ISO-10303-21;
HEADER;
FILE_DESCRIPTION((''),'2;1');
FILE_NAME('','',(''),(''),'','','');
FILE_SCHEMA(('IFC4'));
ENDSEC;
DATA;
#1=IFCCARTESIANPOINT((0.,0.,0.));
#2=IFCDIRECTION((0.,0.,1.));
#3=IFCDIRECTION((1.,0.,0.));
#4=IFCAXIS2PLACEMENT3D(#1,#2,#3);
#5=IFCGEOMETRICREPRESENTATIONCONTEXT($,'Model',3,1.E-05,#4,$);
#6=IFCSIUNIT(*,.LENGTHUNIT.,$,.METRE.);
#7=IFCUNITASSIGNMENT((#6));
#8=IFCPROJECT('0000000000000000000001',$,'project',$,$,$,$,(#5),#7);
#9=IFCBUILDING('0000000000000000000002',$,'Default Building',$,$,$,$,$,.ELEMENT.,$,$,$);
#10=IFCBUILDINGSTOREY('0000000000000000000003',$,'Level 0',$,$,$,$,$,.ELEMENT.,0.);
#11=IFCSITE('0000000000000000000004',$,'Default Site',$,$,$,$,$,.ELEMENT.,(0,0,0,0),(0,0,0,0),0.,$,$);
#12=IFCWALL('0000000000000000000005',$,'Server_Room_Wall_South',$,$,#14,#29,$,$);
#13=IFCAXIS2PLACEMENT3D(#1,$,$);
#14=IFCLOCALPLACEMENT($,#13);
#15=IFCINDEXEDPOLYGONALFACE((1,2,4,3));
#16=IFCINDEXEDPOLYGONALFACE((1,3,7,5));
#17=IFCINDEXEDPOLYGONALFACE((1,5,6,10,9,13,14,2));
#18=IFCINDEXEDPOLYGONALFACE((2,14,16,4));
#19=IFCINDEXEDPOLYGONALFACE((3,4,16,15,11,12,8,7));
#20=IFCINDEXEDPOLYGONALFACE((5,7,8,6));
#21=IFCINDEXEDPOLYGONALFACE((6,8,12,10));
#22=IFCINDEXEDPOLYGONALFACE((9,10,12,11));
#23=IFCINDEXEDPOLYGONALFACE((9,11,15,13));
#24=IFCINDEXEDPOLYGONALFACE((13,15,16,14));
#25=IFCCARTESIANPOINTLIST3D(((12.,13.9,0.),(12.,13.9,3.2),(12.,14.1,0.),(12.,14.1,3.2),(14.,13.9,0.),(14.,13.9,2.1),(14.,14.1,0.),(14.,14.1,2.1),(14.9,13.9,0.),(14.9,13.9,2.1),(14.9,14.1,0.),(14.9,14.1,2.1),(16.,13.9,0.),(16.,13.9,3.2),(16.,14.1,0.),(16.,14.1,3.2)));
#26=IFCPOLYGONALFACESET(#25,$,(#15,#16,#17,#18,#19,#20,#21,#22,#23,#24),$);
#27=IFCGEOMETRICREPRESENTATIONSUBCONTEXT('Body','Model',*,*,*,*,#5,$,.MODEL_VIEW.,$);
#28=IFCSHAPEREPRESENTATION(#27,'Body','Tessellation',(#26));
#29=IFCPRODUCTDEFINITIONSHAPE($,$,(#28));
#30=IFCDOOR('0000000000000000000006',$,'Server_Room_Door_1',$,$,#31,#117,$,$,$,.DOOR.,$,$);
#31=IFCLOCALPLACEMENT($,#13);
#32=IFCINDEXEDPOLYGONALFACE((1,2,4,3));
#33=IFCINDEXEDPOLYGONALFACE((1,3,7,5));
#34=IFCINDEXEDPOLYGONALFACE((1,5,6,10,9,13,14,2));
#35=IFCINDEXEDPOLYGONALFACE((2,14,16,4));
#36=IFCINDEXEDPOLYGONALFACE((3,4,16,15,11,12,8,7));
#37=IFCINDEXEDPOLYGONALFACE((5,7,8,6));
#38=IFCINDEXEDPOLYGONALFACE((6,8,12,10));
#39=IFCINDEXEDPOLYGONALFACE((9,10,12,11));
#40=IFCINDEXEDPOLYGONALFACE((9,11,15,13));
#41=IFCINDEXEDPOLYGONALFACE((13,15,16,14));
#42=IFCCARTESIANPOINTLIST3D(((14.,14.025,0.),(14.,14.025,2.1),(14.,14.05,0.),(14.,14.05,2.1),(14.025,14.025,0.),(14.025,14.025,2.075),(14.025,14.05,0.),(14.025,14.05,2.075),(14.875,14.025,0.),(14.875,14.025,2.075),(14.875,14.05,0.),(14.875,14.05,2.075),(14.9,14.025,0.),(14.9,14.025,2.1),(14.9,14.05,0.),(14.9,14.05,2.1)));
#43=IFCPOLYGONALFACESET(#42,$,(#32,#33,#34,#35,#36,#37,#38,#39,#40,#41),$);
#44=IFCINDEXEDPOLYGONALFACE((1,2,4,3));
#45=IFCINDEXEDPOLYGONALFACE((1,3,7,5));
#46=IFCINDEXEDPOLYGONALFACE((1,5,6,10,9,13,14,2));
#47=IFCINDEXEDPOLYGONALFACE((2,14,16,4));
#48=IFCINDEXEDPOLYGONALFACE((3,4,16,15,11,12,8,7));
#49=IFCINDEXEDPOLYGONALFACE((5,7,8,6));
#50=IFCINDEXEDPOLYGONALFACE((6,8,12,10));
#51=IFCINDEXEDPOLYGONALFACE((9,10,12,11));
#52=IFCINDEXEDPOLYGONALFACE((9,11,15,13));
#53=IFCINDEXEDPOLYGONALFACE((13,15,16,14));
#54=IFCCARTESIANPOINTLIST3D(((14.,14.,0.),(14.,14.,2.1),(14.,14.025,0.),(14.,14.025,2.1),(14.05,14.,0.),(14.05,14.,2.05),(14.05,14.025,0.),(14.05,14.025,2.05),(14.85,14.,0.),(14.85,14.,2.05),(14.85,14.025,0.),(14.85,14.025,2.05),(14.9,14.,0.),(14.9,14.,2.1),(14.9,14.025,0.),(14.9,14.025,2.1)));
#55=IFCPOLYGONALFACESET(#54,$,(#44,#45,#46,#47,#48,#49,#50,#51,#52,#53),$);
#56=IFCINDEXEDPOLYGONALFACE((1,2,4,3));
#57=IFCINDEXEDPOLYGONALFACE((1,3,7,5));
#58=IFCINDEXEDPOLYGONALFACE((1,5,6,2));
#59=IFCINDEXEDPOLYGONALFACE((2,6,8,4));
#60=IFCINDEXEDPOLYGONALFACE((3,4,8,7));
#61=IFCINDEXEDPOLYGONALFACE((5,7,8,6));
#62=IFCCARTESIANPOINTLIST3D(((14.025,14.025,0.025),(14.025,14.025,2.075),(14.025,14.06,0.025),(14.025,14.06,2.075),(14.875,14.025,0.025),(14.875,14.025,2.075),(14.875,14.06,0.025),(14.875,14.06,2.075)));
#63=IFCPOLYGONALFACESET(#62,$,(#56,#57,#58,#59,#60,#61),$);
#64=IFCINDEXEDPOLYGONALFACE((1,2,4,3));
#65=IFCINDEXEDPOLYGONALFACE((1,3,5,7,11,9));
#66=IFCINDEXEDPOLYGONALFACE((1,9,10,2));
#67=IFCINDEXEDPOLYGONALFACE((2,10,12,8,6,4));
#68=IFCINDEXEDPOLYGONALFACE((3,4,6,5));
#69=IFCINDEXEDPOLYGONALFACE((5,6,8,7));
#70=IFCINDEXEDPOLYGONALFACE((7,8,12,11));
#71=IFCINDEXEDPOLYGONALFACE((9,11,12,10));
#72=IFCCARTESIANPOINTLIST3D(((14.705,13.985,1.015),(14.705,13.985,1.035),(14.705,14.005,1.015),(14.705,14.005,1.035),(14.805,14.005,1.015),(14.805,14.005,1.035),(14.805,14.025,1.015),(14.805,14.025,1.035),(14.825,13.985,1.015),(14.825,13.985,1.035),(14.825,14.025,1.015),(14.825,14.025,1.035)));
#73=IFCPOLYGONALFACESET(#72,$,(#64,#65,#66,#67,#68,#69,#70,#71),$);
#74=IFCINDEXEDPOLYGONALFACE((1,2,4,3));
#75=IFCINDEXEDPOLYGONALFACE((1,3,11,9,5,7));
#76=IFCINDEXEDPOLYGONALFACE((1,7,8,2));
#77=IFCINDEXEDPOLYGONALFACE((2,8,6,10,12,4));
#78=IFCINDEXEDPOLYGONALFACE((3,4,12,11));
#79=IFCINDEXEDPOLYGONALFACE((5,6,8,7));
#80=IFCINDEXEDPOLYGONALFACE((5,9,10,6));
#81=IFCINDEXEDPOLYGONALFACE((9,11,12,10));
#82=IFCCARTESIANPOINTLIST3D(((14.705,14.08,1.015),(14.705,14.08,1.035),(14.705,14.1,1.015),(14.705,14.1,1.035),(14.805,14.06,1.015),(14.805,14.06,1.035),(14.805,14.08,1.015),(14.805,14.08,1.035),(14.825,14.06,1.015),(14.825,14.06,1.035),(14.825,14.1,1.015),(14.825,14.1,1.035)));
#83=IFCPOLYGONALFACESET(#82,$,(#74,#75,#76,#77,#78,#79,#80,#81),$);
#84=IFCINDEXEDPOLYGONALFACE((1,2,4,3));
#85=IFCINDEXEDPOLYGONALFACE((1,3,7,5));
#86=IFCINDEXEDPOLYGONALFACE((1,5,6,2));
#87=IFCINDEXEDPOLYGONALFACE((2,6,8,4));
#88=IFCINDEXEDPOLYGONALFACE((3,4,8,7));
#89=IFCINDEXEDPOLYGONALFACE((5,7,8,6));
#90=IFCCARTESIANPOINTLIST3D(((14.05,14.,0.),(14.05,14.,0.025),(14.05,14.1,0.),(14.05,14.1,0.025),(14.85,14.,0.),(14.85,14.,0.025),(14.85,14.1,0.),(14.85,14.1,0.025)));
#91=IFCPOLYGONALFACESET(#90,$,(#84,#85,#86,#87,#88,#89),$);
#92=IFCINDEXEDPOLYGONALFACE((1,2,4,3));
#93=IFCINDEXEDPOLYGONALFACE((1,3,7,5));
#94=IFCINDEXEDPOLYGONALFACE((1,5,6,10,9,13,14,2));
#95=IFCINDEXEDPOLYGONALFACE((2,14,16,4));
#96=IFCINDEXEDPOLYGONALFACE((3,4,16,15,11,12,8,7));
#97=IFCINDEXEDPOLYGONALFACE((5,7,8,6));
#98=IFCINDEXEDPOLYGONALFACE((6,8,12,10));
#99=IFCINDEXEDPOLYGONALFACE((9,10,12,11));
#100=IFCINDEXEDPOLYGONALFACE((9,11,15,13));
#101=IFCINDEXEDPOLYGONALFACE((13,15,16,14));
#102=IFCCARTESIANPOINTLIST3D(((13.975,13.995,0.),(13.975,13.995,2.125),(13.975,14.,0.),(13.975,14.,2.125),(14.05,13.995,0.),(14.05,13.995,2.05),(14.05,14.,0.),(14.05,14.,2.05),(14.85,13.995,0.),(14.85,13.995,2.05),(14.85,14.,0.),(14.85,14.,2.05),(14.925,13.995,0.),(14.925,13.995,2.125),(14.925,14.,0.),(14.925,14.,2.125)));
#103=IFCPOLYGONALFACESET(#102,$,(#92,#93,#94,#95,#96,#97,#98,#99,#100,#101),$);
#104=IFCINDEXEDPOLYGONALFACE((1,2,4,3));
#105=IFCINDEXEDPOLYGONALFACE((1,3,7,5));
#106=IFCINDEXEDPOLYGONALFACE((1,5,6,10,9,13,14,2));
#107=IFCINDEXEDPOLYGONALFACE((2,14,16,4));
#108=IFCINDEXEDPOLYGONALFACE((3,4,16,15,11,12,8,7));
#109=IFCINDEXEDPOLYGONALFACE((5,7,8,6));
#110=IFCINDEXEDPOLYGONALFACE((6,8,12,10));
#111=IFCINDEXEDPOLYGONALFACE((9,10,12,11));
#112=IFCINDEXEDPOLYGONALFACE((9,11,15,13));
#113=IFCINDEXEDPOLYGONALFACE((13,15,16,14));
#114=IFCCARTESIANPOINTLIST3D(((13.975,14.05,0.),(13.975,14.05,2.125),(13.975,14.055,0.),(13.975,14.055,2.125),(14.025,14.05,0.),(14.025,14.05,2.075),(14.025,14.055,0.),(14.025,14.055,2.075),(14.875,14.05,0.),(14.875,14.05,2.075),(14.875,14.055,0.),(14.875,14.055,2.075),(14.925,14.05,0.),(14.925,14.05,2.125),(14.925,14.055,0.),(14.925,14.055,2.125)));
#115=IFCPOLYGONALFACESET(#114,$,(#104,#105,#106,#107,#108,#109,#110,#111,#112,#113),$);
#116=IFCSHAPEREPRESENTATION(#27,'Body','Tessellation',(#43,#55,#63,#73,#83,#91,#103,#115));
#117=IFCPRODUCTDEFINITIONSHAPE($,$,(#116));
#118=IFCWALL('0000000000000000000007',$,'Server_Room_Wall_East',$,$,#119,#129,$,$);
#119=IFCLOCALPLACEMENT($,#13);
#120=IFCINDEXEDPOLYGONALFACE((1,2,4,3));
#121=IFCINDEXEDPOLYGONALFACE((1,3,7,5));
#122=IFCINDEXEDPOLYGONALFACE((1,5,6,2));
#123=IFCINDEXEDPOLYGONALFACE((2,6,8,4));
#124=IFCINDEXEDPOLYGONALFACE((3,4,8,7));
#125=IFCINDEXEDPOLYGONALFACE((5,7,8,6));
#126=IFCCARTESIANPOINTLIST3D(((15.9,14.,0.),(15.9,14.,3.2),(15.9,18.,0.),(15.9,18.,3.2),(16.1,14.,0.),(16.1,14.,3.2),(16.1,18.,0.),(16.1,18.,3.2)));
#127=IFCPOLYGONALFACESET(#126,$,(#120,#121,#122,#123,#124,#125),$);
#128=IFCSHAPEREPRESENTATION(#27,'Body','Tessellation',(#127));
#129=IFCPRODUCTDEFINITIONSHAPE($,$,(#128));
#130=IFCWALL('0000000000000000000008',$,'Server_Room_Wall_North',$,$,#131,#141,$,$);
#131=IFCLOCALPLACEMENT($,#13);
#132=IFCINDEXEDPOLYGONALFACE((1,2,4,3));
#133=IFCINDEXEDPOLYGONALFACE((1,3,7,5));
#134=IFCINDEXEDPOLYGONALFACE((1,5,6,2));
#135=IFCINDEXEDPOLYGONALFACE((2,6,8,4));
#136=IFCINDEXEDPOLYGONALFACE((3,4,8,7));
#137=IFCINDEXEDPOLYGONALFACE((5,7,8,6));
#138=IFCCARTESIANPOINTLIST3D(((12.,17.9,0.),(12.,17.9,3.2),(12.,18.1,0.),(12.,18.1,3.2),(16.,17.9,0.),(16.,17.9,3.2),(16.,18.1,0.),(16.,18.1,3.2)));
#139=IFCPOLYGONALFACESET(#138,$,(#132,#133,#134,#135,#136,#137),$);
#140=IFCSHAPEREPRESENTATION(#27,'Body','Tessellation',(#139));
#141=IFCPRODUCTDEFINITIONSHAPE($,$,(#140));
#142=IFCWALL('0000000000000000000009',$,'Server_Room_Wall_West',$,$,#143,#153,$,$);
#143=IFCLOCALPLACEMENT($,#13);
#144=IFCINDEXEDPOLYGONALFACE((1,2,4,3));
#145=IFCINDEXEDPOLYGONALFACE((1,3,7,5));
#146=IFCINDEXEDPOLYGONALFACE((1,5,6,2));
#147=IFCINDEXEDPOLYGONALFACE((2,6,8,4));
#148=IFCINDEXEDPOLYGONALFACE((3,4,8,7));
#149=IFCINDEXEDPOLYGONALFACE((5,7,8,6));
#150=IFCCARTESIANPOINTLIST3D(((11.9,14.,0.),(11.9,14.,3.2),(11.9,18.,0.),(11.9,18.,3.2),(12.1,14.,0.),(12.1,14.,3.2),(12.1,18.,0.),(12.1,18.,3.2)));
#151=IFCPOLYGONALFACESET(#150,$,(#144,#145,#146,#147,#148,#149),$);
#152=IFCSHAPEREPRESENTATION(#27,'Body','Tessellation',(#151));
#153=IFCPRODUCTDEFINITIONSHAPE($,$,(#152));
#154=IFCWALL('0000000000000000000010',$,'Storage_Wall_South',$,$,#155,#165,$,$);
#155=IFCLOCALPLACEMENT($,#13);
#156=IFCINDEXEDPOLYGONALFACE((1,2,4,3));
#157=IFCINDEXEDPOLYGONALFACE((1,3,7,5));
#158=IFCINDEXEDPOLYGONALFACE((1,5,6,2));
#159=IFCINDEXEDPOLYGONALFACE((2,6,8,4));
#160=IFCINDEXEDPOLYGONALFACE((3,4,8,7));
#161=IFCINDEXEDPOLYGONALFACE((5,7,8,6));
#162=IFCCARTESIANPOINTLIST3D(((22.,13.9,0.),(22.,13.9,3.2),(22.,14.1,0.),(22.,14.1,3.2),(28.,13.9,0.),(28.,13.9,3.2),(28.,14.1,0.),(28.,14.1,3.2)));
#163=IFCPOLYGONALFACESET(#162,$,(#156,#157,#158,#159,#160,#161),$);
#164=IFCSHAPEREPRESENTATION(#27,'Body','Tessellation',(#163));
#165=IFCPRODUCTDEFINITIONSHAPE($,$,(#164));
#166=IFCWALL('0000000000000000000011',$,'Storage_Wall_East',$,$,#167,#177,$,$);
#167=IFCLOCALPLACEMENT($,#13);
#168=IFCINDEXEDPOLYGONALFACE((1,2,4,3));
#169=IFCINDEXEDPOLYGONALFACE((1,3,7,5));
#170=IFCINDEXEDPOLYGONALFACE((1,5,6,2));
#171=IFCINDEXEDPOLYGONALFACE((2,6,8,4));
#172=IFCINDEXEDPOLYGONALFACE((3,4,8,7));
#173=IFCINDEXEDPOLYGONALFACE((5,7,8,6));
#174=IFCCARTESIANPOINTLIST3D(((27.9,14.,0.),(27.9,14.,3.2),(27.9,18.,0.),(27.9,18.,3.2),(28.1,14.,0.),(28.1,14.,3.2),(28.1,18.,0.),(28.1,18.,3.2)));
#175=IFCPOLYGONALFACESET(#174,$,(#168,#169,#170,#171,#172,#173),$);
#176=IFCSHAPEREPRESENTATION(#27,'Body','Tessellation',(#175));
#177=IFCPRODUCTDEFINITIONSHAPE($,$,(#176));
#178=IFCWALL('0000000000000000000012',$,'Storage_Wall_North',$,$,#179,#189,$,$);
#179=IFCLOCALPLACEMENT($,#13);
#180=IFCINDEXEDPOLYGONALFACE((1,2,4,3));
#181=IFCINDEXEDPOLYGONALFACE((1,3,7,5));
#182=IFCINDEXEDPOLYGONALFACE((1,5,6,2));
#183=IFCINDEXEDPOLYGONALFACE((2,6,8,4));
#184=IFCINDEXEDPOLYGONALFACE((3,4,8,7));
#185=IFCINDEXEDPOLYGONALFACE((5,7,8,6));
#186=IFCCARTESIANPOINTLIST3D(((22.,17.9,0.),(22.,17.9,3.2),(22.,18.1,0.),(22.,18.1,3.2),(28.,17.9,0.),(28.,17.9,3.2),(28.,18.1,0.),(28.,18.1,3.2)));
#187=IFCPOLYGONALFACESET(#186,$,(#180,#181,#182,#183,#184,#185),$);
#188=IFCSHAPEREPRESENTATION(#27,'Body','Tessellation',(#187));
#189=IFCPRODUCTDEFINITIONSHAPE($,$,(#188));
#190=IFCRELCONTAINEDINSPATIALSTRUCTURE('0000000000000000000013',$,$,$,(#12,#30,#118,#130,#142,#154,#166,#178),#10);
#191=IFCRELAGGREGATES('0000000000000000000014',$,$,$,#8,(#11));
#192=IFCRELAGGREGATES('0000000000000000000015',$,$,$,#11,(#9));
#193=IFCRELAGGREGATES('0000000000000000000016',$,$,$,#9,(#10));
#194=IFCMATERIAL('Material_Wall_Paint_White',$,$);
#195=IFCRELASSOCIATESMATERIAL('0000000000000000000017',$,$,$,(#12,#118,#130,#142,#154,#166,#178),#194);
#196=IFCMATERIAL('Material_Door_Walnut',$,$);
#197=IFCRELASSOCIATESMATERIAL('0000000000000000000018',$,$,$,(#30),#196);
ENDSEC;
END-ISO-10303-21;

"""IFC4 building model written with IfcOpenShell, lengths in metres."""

from ifc_helpers import new_model, si_unit, frame, origin_with_axes, place, context, subcontext, project, spatial, line, indexed_curve, outline, extrude, material, element, fill, save


model = new_model("IFC4")

# Units and contexts
model_context = context("Model", 3, precision=1e-05, world=origin_with_axes())
body_context = subcontext(model_context, "Body", "Model", "MODEL_VIEW")
ifc_project = project(units=[si_unit("LENGTHUNIT", "METRE")], contexts=[model_context])

# Site, building, storey
site = spatial("IfcSite", under=ifc_project, Name="Default Site", CompositionType="ELEMENT", RefLatitude=(0, 0, 0, 0), RefLongitude=(0, 0, 0, 0), RefElevation=0.0)
building = spatial("IfcBuilding", under=site, Name="Default Building", CompositionType="ELEMENT")
storey = spatial("IfcBuildingStorey", under=building, Name="Level 0", CompositionType="ELEMENT", Elevation=0.0)

# Shared definitions
ifc_material_1 = material(Name="Material_Wall_Paint_White")

# Wall, opening, door
wall_1_placement = place(None, frame((12.0, 14.0, 0.0), z_axis=(0.0, 0.0, 1.0), x_axis=(1.0, 0.0, 0.0)))
wall_1 = element("IfcWall", 1, at=wall_1_placement, inside=storey, material=ifc_material_1, Name="Server_Room_Wall_South", context=body_context, shape_type="SweptSolid", body=[
    extrude(outline(indexed_curve([(0.0, 0.0), (0.0, 0.2), (4.0, 0.2), (4.0, 0.0), (0.0, 0.0)], self_intersect=False)), frame((0.0, -0.1, 0.0), z_axis=(0.0, 0.0, 1.0), x_axis=(1.0, 0.0, 0.0)), (0.0, 0.0, 1.0), 3.2),
])
opening_1_placement = place(wall_1_placement, frame((2.0, -0.5, 0.0), z_axis=(0.0, 0.0, 1.0), x_axis=(1.0, 0.0, 0.0)))
opening_1 = element("IfcOpeningElement", 2, at=opening_1_placement, inside=storey, cuts=wall_1, PredefinedType="OPENING", context=body_context, shape_type="SweptSolid", body=[
    extrude(outline(indexed_curve([(0.0, 0.0), (0.0, 1.0), (0.9, 1.0), (0.9, 0.0), (0.0, 0.0)], self_intersect=False)), origin_with_axes(), (0.0, 0.0, 1.0), 2.1),
])
ifc_material_2 = material(Name="Material_Door_Walnut")
door_1_placement = place(None, frame((14.0, 14.0, 0.0), z_axis=(0.0, 0.0, 1.0), x_axis=(1.0, 0.0, 0.0)))
door_1 = element("IfcDoor", 3, at=door_1_placement, inside=storey, material=ifc_material_2, Name="Server_Room_Door_1", PredefinedType="DOOR", context=body_context, shape_type="SweptSolid", body=[
    extrude(outline(indexed_curve([(0.0, 0.0), (0.0, 2.1), (0.9, 2.1), (0.9, 0.0), (0.875, 0.0), (0.875, 2.075), (0.025, 2.075), (0.025, 0.0)], segments=[line(1, 2, 3, 4, 5, 6, 7, 8, 1)])), frame((0.0, 0.025, 0.0), z_axis=(0.0, -1.0, 0.0), x_axis=(1.0, 0.0, 0.0)), (0.0, 0.0, -1.0), 0.025),
    extrude(outline(indexed_curve([(0.0, 0.0), (0.0, 2.1), (0.9, 2.1), (0.9, 0.0), (0.85, 0.0), (0.85, 2.05), (0.05, 2.05), (0.05, 0.0)], segments=[line(1, 2, 3, 4, 5, 6, 7, 8, 1)])), frame((0.0, 0.0, 0.0), z_axis=(0.0, -1.0, 0.0), x_axis=(1.0, 0.0, 0.0)), (0.0, 0.0, -1.0), 0.025),
    extrude(outline(indexed_curve([(0.0, 0.0), (0.85, 0.0), (0.85, 0.035), (0.0, 0.035)], segments=[line(1, 2, 3, 4, 1)])), frame((0.025, 0.025, 0.025), z_axis=(0.0, 0.0, 1.0), x_axis=(1.0, 0.0, 0.0)), (0.0, 0.0, 1.0), 2.05),
    extrude(outline(indexed_curve([(0.0, 0.0), (0.0, -0.04), (-0.12, -0.04), (-0.12, -0.02), (-0.02, -0.02), (-0.02, 0.0)], segments=[line(1, 2, 3, 4, 5, 6, 1)])), frame((0.825, 0.025, 1.015), z_axis=(0.0, 0.0, 1.0), x_axis=(1.0, 0.0, 0.0)), (0.0, 0.0, 1.0), 0.02),
    extrude(outline(indexed_curve([(0.0, 0.0), (0.0, 0.04), (-0.12, 0.04), (-0.12, 0.02), (-0.02, 0.02), (-0.02, 0.0)], segments=[line(1, 2, 3, 4, 5, 6, 1)])), frame((0.825, 0.06, 1.015), z_axis=(0.0, 0.0, 1.0), x_axis=(1.0, 0.0, 0.0)), (0.0, 0.0, 1.0), 0.02),
    extrude(outline(indexed_curve([(0.0, 0.0), (0.8, 0.0), (0.8, 0.1), (0.0, 0.1)], segments=[line(1, 2, 3, 4, 1)])), frame((0.05, 0.0, 0.0), z_axis=(0.0, 0.0, 1.0), x_axis=(1.0, 0.0, 0.0)), (0.0, 0.0, 1.0), 0.025),
    extrude(outline(indexed_curve([(0.0, 0.0), (0.0, 2.125), (0.95, 2.125), (0.95, 0.0), (0.875, 0.0), (0.875, 2.05), (0.075, 2.05), (0.075, 0.0)], segments=[line(1, 2, 3, 4, 5, 6, 7, 8, 1)])), frame((-0.025, -0.005, 0.0), z_axis=(0.0, -1.0, 0.0), x_axis=(1.0, 0.0, 0.0)), (0.0, 0.0, -1.0), 0.005),
    extrude(outline(indexed_curve([(0.0, 0.0), (0.0, 2.125), (0.95, 2.125), (0.95, 0.0), (0.9, 0.0), (0.9, 2.075), (0.05, 2.075), (0.05, 0.0)], segments=[line(1, 2, 3, 4, 5, 6, 7, 8, 1)])), frame((-0.025, 0.05, 0.0), z_axis=(0.0, -1.0, 0.0), x_axis=(1.0, 0.0, 0.0)), (0.0, 0.0, -1.0), 0.005),
])
fill(opening_1, door_1)

# Walls
for number, where, z_axis, x_axis, name in (
    (4, (16.0, 14.0, 0.0), (0.0, 0.0, 1.0), (0.0, 1.0, 0.0), "Server_Room_Wall_East"),
    (5, (16.0, 18.0, 0.0), (0.0, 0.0, 1.0), (-1.0, 0.0, 0.0), "Server_Room_Wall_North"),
    (6, (12.0, 18.0, 0.0), (0.0, 0.0, 1.0), (0.0, -1.0, 0.0), "Server_Room_Wall_West"),
):
    element("IfcWall", number, at=place(None, frame(where, z_axis=z_axis, x_axis=x_axis)), inside=storey, material=ifc_material_1, Name=name, context=body_context, shape_type="SweptSolid", body=[
        extrude(outline(indexed_curve([(0.0, 0.0), (0.0, 0.2), (4.0, 0.2), (4.0, 0.0), (0.0, 0.0)], self_intersect=False)), frame((0.0, -0.1, 0.0), z_axis=(0.0, 0.0, 1.0), x_axis=(1.0, 0.0, 0.0)), (0.0, 0.0, 1.0), 3.2),
    ])
wall_2_placement = place(None, frame((22.0, 14.0, 0.0), z_axis=(0.0, 0.0, 1.0), x_axis=(1.0, 0.0, 0.0)))
element("IfcWall", 7, at=wall_2_placement, inside=storey, material=ifc_material_1, Name="Storage_Wall_South", context=body_context, shape_type="SweptSolid", body=[
    extrude(outline(indexed_curve([(0.0, 0.0), (0.0, 0.2), (6.0, 0.2), (6.0, 0.0), (0.0, 0.0)], self_intersect=False)), frame((0.0, -0.1, 0.0), z_axis=(0.0, 0.0, 1.0), x_axis=(1.0, 0.0, 0.0)), (0.0, 0.0, 1.0), 3.2),
])
wall_3_placement = place(None, frame((28.0, 14.0, 0.0), z_axis=(0.0, 0.0, 1.0), x_axis=(0.0, 1.0, 0.0)))
element("IfcWall", 8, at=wall_3_placement, inside=storey, material=ifc_material_1, Name="Storage_Wall_East", context=body_context, shape_type="SweptSolid", body=[
    extrude(outline(indexed_curve([(0.0, 0.0), (0.0, 0.2), (4.0, 0.2), (4.0, 0.0), (0.0, 0.0)], self_intersect=False)), frame((0.0, -0.1, 0.0), z_axis=(0.0, 0.0, 1.0), x_axis=(1.0, 0.0, 0.0)), (0.0, 0.0, 1.0), 3.2),
])
wall_4_placement = place(None, frame((28.0, 18.0, 0.0), z_axis=(0.0, 0.0, 1.0), x_axis=(-1.0, 0.0, 0.0)))
element("IfcWall", 9, at=wall_4_placement, inside=storey, material=ifc_material_1, Name="Storage_Wall_North", context=body_context, shape_type="SweptSolid", body=[
    extrude(outline(indexed_curve([(0.0, 0.0), (0.0, 0.2), (6.0, 0.2), (6.0, 0.0), (0.0, 0.0)], self_intersect=False)), frame((0.0, -0.1, 0.0), z_axis=(0.0, 0.0, 1.0), x_axis=(1.0, 0.0, 0.0)), (0.0, 0.0, 1.0), 3.2),
])

save(model, "model.ifc")
